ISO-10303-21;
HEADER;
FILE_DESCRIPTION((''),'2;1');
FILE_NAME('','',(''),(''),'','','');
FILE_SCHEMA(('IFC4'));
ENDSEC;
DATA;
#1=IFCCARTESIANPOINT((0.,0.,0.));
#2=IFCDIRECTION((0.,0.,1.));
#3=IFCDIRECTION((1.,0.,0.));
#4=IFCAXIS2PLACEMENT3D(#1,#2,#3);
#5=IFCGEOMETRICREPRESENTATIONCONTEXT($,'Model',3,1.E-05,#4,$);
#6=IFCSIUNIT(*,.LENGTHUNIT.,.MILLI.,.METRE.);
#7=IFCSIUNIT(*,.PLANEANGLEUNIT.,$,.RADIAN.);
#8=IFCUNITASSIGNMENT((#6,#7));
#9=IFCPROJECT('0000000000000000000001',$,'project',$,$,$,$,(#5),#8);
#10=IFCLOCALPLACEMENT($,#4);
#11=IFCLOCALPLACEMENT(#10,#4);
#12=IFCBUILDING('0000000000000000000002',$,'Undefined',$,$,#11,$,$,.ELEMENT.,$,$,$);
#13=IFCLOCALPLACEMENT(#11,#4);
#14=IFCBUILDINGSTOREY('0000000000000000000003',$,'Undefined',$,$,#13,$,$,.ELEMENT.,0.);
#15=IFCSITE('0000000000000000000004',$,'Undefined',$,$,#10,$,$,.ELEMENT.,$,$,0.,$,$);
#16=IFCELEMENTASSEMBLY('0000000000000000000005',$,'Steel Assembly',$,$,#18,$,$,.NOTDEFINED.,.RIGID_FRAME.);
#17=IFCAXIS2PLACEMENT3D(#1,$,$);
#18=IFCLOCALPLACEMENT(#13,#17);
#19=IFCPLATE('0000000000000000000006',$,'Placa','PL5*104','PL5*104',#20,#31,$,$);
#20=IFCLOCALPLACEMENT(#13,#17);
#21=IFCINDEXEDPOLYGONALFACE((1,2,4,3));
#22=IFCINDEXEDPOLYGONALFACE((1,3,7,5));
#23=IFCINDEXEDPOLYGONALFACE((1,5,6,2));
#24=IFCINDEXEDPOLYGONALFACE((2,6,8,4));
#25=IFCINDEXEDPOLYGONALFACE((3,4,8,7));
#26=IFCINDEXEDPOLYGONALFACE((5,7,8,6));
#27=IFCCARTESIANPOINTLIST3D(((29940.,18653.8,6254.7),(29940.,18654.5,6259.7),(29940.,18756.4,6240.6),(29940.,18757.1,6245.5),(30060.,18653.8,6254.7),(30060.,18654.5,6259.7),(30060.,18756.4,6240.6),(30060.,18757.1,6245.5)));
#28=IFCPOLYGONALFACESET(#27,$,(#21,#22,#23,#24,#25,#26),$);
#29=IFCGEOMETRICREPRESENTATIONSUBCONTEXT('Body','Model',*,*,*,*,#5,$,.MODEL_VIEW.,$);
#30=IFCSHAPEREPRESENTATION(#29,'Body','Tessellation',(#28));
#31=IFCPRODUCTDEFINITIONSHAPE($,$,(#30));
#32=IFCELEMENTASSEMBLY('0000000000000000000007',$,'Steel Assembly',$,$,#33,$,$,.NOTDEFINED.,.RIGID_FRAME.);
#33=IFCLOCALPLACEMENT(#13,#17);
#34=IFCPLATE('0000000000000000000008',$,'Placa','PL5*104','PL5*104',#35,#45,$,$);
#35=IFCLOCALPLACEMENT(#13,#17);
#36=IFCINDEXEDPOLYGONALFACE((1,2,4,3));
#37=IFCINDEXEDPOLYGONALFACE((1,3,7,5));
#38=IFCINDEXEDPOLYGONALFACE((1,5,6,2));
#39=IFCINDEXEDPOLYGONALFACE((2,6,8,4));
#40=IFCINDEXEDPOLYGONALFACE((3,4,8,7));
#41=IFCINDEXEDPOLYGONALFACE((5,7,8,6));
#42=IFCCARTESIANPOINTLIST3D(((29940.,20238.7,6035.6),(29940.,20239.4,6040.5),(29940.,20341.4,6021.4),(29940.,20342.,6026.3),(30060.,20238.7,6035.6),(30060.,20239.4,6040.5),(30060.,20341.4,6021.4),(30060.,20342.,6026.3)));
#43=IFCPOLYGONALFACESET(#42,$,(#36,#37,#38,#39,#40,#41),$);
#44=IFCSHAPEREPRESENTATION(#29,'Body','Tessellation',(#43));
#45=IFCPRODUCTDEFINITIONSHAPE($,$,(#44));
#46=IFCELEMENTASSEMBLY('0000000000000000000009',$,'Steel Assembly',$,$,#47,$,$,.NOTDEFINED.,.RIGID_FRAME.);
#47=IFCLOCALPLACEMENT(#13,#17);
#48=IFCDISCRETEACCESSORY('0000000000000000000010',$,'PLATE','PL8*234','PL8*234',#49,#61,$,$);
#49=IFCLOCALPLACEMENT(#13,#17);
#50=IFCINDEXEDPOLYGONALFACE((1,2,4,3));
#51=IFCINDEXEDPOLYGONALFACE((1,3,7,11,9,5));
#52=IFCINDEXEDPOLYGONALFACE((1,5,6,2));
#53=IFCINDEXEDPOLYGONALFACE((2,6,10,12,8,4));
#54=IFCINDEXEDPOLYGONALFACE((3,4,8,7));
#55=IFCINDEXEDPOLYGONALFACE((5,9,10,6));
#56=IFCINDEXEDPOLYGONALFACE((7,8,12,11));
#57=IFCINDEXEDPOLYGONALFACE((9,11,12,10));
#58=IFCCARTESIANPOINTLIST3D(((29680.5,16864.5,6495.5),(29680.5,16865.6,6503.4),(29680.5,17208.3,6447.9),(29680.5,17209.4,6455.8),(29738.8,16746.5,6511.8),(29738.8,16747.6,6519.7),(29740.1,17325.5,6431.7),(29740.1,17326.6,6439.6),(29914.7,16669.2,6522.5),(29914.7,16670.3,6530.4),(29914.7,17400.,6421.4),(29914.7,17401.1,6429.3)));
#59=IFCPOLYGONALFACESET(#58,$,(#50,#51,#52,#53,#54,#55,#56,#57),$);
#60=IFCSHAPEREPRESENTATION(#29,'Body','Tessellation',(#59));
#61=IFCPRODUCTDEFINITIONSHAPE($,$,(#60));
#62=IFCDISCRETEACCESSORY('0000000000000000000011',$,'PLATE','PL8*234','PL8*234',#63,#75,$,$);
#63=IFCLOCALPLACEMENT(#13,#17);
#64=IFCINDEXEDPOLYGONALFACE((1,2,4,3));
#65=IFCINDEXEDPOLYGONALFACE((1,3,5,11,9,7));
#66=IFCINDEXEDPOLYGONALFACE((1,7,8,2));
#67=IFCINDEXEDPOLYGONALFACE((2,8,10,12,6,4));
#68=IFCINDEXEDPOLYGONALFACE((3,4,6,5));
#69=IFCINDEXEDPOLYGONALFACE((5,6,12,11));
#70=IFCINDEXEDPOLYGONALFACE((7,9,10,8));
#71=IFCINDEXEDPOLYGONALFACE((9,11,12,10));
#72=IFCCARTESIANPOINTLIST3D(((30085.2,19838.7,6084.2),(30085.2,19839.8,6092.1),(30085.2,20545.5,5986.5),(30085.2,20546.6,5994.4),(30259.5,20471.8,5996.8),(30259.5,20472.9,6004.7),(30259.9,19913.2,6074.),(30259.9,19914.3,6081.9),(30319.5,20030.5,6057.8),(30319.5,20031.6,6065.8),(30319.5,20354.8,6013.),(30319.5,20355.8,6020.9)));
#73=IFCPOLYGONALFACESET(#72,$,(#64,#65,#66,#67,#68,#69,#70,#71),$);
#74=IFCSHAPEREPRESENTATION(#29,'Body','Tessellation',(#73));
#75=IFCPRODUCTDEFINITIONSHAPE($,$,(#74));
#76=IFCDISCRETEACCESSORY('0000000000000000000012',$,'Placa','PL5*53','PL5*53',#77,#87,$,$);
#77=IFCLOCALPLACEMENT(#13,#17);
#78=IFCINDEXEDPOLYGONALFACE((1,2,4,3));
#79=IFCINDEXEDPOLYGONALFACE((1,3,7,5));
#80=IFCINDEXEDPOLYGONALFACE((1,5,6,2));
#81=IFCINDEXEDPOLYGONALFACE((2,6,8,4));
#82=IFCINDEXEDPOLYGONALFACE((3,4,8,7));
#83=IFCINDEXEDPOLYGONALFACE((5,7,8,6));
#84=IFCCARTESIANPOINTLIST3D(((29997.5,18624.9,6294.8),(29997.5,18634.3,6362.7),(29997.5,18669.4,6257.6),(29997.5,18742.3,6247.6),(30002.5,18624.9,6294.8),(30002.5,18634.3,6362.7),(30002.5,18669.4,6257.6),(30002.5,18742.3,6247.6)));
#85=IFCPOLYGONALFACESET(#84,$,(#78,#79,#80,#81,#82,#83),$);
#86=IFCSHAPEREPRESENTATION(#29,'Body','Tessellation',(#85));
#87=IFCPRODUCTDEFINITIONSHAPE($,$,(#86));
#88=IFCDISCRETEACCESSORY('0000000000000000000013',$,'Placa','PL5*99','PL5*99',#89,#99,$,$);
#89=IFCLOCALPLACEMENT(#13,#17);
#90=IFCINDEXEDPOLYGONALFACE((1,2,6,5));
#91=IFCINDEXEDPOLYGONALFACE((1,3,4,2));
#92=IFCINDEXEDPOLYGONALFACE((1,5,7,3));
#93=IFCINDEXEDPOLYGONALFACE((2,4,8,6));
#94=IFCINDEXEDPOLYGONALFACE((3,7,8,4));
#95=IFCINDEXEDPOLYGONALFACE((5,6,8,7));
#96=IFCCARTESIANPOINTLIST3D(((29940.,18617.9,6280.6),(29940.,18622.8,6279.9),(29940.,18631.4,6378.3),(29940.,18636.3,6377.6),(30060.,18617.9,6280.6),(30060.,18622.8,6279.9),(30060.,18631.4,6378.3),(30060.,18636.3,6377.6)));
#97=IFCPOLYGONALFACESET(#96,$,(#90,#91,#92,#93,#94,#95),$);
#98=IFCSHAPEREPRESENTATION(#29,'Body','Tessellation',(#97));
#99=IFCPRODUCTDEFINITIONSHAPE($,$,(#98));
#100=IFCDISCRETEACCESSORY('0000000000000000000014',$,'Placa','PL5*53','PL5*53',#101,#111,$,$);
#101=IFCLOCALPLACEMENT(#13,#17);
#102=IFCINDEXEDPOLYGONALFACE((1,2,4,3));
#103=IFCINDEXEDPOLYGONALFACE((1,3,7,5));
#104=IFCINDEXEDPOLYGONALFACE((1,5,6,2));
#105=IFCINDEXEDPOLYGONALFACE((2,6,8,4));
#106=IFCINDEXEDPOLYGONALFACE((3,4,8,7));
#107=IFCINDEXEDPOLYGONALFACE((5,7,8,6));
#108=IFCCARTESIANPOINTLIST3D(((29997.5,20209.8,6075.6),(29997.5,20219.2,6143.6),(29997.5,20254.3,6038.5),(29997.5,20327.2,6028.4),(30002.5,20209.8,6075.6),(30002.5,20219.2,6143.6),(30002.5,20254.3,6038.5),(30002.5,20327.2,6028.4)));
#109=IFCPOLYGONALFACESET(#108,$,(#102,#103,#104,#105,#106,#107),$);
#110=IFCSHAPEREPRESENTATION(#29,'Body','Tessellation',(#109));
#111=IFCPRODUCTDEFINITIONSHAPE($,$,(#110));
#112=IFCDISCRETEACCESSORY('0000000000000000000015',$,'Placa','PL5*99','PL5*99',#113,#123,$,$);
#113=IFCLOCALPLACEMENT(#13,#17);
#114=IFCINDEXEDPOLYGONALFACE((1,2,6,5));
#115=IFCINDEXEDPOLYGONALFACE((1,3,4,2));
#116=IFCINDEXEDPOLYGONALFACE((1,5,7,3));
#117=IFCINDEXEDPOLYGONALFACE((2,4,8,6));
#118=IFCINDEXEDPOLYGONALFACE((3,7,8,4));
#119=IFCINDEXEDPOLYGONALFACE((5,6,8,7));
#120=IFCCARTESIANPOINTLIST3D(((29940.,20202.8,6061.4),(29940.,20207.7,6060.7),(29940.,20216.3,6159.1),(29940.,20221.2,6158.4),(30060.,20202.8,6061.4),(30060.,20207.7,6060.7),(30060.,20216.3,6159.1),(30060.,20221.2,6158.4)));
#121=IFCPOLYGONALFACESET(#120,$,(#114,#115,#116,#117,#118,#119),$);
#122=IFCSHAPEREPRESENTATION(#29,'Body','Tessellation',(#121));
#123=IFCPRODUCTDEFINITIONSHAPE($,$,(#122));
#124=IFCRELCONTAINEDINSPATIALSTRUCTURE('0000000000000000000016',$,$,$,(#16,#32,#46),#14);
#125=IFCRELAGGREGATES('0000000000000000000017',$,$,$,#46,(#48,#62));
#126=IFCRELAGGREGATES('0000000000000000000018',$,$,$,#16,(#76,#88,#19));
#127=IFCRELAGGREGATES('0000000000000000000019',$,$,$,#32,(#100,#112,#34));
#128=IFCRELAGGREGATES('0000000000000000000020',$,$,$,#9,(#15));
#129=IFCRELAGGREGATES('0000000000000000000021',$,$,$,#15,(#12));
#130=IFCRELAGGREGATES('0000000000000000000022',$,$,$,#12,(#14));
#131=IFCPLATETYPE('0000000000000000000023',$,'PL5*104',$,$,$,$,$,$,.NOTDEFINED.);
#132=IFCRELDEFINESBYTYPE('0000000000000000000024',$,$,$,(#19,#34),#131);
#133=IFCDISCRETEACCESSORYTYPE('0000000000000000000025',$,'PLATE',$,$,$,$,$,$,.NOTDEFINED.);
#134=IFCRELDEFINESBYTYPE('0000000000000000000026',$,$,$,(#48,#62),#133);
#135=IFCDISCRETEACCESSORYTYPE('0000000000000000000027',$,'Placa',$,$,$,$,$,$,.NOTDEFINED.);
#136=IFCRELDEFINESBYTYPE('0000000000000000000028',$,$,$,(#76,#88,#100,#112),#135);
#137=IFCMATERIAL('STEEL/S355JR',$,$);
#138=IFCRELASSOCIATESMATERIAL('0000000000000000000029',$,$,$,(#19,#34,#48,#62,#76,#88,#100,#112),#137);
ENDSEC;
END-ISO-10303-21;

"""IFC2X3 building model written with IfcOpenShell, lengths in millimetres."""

from ifc_helpers import new_model, si_unit, frame, origin_with_axes, place, context, subcontext, project, spatial, polyline, outline, extrude, material, type_object, element, aggregate, save


model = new_model("IFC2X3")

# Units and contexts
model_context = context("Model", 3, precision=1e-05, world=origin_with_axes())
body_context = subcontext(model_context, "Body", "Model", "MODEL_VIEW")
ifc_project = project(units=[si_unit("LENGTHUNIT", "METRE", prefix="MILLI"), si_unit("PLANEANGLEUNIT", "RADIAN")], contexts=[model_context])

# Site, building, storey
site_placement = place(None, origin_with_axes())
site = spatial("IfcSite", under=ifc_project, at=site_placement, Name="Undefined", CompositionType="ELEMENT", RefElevation=0.0)
building_placement = place(site_placement, origin_with_axes())
building = spatial("IfcBuilding", under=site, at=building_placement, Name="Undefined", CompositionType="ELEMENT")
storey_placement = place(building_placement, origin_with_axes())
storey = spatial("IfcBuildingStorey", under=building, at=storey_placement, Name="Undefined", CompositionType="ELEMENT", Elevation=0.0)

# Shared definitions
ifc_material_1 = material(Name="STEEL/S355JR")

# Element assemblies, plates
assembly_1_placement = place(storey_placement, origin_with_axes())
assembly_1 = element("IfcElementAssembly", 1, at=assembly_1_placement, inside=storey, Name="Steel Assembly", AssemblyPlace="NOTDEFINED", PredefinedType="RIGID_FRAME")
plate_type = type_object("IfcPlateType", Name="PL5*104", PredefinedType="NOTDEFINED")
plate_1_placement = place(assembly_1_placement, frame((29940.0, 18654.2, 6257.2), z_axis=(0.0, -0.136905, -0.990584), x_axis=(0.0, 0.990584, -0.136905)))
plate_1 = element("IfcPlate", 2, at=plate_1_placement, type_object=plate_type, material=ifc_material_1, Name="Placa", Description="PL5*104", ObjectType="PL5*104", context=body_context, shape_type="SweptSolid", body=[
    extrude(outline(polyline([(0.0, 0.0), (103.6, 0.0), (103.6, 120.0), (0.0, 120.0), (0.0, 0.0)])), frame((0.0, 0.0, -2.5), z_axis=(0.0, 0.0, 1.0), x_axis=(1.0, 0.0, 0.0)), (0.0, 0.0, 1.0), 5.0),
])
assembly_2_placement = place(storey_placement, origin_with_axes())
assembly_2 = element("IfcElementAssembly", 3, at=assembly_2_placement, inside=storey, Name="Steel Assembly", AssemblyPlace="NOTDEFINED", PredefinedType="RIGID_FRAME")
plate_2_placement = place(assembly_2_placement, frame((29940.0, 20239.1, 6038.0), z_axis=(0.0, -0.136905, -0.990584), x_axis=(0.0, 0.990584, -0.136905)))
plate_2 = element("IfcPlate", 4, at=plate_2_placement, type_object=plate_type, material=ifc_material_1, Name="Placa", Description="PL5*104", ObjectType="PL5*104", context=body_context, shape_type="SweptSolid", body=[
    extrude(outline(polyline([(0.0, 0.0), (103.6, 0.0), (103.6, 120.0), (0.0, 120.0), (0.0, 0.0)])), frame((0.0, 0.0, -2.5), z_axis=(0.0, 0.0, 1.0), x_axis=(1.0, 0.0, 0.0)), (0.0, 0.0, 1.0), 5.0),
])

# Element assembly, discrete accessories
assembly_3_placement = place(storey_placement, origin_with_axes())
assembly_3 = element("IfcElementAssembly", 5, at=assembly_3_placement, inside=storey, Name="Steel Assembly", AssemblyPlace="NOTDEFINED", PredefinedType="RIGID_FRAME")
discrete_accessory_type_1 = type_object("IfcDiscreteAccessoryType", Name="PLATE")
discrete_accessory_1_placement = place(assembly_3_placement, frame((29914.7, 17400.5, 6425.4), z_axis=(0.000018, -0.13698, -0.990574), x_axis=(0.0, -0.990574, 0.13698)))
discrete_accessory_1 = element("IfcDiscreteAccessory", 6, at=discrete_accessory_1_placement, type_object=discrete_accessory_type_1, material=ifc_material_1, Name="PLATE", Description="PL8*234", ObjectType="PL8*234", context=body_context, shape_type="SweptSolid", body=[
    extrude(outline(polyline([(0.0, 0.0), (737.8, 0.0), (659.7, 175.9), (540.6, 234.3), (193.6, 234.3), (75.2, 174.6), (0.0, 0.0)])), frame((0.0, 0.0, -4.0), z_axis=(0.0, 0.0, 1.0), x_axis=(1.0, 0.0, 0.0)), (0.0, 0.0, 1.0), 8.0),
])
discrete_accessory_2_placement = place(assembly_3_placement, frame((30085.2, 20546.0, 5990.5), z_axis=(-0.000554, 0.13698, 0.990574), x_axis=(0.0, -0.990574, 0.13698)))
discrete_accessory_2 = element("IfcDiscreteAccessory", 7, at=discrete_accessory_2_placement, type_object=discrete_accessory_type_1, material=ifc_material_1, Name="PLATE", Description="PL8*234", ObjectType="PL8*234", context=body_context, shape_type="SweptSolid", body=[
    extrude(outline(polyline([(0.0, 0.0), (713.5, 0.0), (638.3, 174.6), (519.9, 234.3), (192.5, 234.3), (74.3, 174.2), (0.0, 0.0)])), frame((0.0, 0.0, -4.0), z_axis=(0.0, 0.0, 1.0), x_axis=(1.0, 0.0, 0.0)), (0.0, 0.0, 1.0), 8.0),
])
aggregate(assembly_3, [discrete_accessory_1, discrete_accessory_2])

# Discrete accessories
discrete_accessory_type_2 = type_object("IfcDiscreteAccessoryType", Name="Placa")
discrete_accessory_3_placement = place(assembly_1_placement, frame((30000.0, 18634.3, 6362.7), z_axis=(-1.0, 0.0, 0.0), x_axis=(0.0, 0.684057, -0.729429)))
discrete_accessory_3 = element("IfcDiscreteAccessory", 8, at=discrete_accessory_3_placement, type_object=discrete_accessory_type_2, material=ifc_material_1, Name="Placa", Description="PL5*53", ObjectType="PL5*53", context=body_context, shape_type="SweptSolid", body=[
    extrude(outline(polyline([(0.0, 0.0), (157.9, 0.0), (100.7, 46.3), (43.1, 53.3), (0.0, 0.0)])), frame((0.0, 0.0, -2.5), z_axis=(0.0, 0.0, 1.0), x_axis=(1.0, 0.0, 0.0)), (0.0, 0.0, 1.0), 5.0),
])
discrete_accessory_4_placement = place(assembly_1_placement, frame((29940.0, 18620.3, 6280.3), z_axis=(0.0, 0.990592, -0.136849), x_axis=(0.0, 0.136849, 0.990592)))
discrete_accessory_4 = element("IfcDiscreteAccessory", 9, at=discrete_accessory_4_placement, type_object=discrete_accessory_type_2, material=ifc_material_1, Name="Placa", Description="PL5*99", ObjectType="PL5*99", context=body_context, shape_type="SweptSolid", body=[
    extrude(outline(polyline([(0.0, 0.0), (98.6, 0.0), (98.6, 120.0), (0.0, 120.0), (0.0, 0.0)])), frame((0.0, 0.0, -2.5), z_axis=(0.0, 0.0, 1.0), x_axis=(1.0, 0.0, 0.0)), (0.0, 0.0, 1.0), 5.0),
])
discrete_accessory_5_placement = place(assembly_2_placement, frame((30000.0, 20219.2, 6143.6), z_axis=(-1.0, 0.0, 0.0), x_axis=(0.0, 0.684057, -0.729429)))
discrete_accessory_5 = element("IfcDiscreteAccessory", 10, at=discrete_accessory_5_placement, type_object=discrete_accessory_type_2, material=ifc_material_1, Name="Placa", Description="PL5*53", ObjectType="PL5*53", context=body_context, shape_type="SweptSolid", body=[
    extrude(outline(polyline([(0.0, 0.0), (157.9, 0.0), (100.7, 46.3), (43.1, 53.3), (0.0, 0.0)])), frame((0.0, 0.0, -2.5), z_axis=(0.0, 0.0, 1.0), x_axis=(1.0, 0.0, 0.0)), (0.0, 0.0, 1.0), 5.0),
])
discrete_accessory_6_placement = place(assembly_2_placement, frame((29940.0, 20205.3, 6061.1), z_axis=(0.0, 0.990592, -0.136849), x_axis=(0.0, 0.136849, 0.990592)))
discrete_accessory_6 = element("IfcDiscreteAccessory", 11, at=discrete_accessory_6_placement, type_object=discrete_accessory_type_2, material=ifc_material_1, Name="Placa", Description="PL5*99", ObjectType="PL5*99", context=body_context, shape_type="SweptSolid", body=[
    extrude(outline(polyline([(0.0, 0.0), (98.6, 0.0), (98.6, 120.0), (0.0, 120.0), (0.0, 0.0)])), frame((0.0, 0.0, -2.5), z_axis=(0.0, 0.0, 1.0), x_axis=(1.0, 0.0, 0.0)), (0.0, 0.0, 1.0), 5.0),
])

aggregate(assembly_1, [discrete_accessory_3, discrete_accessory_4, plate_1])
aggregate(assembly_2, [discrete_accessory_5, discrete_accessory_6, plate_2])

save(model, "model.ifc")
